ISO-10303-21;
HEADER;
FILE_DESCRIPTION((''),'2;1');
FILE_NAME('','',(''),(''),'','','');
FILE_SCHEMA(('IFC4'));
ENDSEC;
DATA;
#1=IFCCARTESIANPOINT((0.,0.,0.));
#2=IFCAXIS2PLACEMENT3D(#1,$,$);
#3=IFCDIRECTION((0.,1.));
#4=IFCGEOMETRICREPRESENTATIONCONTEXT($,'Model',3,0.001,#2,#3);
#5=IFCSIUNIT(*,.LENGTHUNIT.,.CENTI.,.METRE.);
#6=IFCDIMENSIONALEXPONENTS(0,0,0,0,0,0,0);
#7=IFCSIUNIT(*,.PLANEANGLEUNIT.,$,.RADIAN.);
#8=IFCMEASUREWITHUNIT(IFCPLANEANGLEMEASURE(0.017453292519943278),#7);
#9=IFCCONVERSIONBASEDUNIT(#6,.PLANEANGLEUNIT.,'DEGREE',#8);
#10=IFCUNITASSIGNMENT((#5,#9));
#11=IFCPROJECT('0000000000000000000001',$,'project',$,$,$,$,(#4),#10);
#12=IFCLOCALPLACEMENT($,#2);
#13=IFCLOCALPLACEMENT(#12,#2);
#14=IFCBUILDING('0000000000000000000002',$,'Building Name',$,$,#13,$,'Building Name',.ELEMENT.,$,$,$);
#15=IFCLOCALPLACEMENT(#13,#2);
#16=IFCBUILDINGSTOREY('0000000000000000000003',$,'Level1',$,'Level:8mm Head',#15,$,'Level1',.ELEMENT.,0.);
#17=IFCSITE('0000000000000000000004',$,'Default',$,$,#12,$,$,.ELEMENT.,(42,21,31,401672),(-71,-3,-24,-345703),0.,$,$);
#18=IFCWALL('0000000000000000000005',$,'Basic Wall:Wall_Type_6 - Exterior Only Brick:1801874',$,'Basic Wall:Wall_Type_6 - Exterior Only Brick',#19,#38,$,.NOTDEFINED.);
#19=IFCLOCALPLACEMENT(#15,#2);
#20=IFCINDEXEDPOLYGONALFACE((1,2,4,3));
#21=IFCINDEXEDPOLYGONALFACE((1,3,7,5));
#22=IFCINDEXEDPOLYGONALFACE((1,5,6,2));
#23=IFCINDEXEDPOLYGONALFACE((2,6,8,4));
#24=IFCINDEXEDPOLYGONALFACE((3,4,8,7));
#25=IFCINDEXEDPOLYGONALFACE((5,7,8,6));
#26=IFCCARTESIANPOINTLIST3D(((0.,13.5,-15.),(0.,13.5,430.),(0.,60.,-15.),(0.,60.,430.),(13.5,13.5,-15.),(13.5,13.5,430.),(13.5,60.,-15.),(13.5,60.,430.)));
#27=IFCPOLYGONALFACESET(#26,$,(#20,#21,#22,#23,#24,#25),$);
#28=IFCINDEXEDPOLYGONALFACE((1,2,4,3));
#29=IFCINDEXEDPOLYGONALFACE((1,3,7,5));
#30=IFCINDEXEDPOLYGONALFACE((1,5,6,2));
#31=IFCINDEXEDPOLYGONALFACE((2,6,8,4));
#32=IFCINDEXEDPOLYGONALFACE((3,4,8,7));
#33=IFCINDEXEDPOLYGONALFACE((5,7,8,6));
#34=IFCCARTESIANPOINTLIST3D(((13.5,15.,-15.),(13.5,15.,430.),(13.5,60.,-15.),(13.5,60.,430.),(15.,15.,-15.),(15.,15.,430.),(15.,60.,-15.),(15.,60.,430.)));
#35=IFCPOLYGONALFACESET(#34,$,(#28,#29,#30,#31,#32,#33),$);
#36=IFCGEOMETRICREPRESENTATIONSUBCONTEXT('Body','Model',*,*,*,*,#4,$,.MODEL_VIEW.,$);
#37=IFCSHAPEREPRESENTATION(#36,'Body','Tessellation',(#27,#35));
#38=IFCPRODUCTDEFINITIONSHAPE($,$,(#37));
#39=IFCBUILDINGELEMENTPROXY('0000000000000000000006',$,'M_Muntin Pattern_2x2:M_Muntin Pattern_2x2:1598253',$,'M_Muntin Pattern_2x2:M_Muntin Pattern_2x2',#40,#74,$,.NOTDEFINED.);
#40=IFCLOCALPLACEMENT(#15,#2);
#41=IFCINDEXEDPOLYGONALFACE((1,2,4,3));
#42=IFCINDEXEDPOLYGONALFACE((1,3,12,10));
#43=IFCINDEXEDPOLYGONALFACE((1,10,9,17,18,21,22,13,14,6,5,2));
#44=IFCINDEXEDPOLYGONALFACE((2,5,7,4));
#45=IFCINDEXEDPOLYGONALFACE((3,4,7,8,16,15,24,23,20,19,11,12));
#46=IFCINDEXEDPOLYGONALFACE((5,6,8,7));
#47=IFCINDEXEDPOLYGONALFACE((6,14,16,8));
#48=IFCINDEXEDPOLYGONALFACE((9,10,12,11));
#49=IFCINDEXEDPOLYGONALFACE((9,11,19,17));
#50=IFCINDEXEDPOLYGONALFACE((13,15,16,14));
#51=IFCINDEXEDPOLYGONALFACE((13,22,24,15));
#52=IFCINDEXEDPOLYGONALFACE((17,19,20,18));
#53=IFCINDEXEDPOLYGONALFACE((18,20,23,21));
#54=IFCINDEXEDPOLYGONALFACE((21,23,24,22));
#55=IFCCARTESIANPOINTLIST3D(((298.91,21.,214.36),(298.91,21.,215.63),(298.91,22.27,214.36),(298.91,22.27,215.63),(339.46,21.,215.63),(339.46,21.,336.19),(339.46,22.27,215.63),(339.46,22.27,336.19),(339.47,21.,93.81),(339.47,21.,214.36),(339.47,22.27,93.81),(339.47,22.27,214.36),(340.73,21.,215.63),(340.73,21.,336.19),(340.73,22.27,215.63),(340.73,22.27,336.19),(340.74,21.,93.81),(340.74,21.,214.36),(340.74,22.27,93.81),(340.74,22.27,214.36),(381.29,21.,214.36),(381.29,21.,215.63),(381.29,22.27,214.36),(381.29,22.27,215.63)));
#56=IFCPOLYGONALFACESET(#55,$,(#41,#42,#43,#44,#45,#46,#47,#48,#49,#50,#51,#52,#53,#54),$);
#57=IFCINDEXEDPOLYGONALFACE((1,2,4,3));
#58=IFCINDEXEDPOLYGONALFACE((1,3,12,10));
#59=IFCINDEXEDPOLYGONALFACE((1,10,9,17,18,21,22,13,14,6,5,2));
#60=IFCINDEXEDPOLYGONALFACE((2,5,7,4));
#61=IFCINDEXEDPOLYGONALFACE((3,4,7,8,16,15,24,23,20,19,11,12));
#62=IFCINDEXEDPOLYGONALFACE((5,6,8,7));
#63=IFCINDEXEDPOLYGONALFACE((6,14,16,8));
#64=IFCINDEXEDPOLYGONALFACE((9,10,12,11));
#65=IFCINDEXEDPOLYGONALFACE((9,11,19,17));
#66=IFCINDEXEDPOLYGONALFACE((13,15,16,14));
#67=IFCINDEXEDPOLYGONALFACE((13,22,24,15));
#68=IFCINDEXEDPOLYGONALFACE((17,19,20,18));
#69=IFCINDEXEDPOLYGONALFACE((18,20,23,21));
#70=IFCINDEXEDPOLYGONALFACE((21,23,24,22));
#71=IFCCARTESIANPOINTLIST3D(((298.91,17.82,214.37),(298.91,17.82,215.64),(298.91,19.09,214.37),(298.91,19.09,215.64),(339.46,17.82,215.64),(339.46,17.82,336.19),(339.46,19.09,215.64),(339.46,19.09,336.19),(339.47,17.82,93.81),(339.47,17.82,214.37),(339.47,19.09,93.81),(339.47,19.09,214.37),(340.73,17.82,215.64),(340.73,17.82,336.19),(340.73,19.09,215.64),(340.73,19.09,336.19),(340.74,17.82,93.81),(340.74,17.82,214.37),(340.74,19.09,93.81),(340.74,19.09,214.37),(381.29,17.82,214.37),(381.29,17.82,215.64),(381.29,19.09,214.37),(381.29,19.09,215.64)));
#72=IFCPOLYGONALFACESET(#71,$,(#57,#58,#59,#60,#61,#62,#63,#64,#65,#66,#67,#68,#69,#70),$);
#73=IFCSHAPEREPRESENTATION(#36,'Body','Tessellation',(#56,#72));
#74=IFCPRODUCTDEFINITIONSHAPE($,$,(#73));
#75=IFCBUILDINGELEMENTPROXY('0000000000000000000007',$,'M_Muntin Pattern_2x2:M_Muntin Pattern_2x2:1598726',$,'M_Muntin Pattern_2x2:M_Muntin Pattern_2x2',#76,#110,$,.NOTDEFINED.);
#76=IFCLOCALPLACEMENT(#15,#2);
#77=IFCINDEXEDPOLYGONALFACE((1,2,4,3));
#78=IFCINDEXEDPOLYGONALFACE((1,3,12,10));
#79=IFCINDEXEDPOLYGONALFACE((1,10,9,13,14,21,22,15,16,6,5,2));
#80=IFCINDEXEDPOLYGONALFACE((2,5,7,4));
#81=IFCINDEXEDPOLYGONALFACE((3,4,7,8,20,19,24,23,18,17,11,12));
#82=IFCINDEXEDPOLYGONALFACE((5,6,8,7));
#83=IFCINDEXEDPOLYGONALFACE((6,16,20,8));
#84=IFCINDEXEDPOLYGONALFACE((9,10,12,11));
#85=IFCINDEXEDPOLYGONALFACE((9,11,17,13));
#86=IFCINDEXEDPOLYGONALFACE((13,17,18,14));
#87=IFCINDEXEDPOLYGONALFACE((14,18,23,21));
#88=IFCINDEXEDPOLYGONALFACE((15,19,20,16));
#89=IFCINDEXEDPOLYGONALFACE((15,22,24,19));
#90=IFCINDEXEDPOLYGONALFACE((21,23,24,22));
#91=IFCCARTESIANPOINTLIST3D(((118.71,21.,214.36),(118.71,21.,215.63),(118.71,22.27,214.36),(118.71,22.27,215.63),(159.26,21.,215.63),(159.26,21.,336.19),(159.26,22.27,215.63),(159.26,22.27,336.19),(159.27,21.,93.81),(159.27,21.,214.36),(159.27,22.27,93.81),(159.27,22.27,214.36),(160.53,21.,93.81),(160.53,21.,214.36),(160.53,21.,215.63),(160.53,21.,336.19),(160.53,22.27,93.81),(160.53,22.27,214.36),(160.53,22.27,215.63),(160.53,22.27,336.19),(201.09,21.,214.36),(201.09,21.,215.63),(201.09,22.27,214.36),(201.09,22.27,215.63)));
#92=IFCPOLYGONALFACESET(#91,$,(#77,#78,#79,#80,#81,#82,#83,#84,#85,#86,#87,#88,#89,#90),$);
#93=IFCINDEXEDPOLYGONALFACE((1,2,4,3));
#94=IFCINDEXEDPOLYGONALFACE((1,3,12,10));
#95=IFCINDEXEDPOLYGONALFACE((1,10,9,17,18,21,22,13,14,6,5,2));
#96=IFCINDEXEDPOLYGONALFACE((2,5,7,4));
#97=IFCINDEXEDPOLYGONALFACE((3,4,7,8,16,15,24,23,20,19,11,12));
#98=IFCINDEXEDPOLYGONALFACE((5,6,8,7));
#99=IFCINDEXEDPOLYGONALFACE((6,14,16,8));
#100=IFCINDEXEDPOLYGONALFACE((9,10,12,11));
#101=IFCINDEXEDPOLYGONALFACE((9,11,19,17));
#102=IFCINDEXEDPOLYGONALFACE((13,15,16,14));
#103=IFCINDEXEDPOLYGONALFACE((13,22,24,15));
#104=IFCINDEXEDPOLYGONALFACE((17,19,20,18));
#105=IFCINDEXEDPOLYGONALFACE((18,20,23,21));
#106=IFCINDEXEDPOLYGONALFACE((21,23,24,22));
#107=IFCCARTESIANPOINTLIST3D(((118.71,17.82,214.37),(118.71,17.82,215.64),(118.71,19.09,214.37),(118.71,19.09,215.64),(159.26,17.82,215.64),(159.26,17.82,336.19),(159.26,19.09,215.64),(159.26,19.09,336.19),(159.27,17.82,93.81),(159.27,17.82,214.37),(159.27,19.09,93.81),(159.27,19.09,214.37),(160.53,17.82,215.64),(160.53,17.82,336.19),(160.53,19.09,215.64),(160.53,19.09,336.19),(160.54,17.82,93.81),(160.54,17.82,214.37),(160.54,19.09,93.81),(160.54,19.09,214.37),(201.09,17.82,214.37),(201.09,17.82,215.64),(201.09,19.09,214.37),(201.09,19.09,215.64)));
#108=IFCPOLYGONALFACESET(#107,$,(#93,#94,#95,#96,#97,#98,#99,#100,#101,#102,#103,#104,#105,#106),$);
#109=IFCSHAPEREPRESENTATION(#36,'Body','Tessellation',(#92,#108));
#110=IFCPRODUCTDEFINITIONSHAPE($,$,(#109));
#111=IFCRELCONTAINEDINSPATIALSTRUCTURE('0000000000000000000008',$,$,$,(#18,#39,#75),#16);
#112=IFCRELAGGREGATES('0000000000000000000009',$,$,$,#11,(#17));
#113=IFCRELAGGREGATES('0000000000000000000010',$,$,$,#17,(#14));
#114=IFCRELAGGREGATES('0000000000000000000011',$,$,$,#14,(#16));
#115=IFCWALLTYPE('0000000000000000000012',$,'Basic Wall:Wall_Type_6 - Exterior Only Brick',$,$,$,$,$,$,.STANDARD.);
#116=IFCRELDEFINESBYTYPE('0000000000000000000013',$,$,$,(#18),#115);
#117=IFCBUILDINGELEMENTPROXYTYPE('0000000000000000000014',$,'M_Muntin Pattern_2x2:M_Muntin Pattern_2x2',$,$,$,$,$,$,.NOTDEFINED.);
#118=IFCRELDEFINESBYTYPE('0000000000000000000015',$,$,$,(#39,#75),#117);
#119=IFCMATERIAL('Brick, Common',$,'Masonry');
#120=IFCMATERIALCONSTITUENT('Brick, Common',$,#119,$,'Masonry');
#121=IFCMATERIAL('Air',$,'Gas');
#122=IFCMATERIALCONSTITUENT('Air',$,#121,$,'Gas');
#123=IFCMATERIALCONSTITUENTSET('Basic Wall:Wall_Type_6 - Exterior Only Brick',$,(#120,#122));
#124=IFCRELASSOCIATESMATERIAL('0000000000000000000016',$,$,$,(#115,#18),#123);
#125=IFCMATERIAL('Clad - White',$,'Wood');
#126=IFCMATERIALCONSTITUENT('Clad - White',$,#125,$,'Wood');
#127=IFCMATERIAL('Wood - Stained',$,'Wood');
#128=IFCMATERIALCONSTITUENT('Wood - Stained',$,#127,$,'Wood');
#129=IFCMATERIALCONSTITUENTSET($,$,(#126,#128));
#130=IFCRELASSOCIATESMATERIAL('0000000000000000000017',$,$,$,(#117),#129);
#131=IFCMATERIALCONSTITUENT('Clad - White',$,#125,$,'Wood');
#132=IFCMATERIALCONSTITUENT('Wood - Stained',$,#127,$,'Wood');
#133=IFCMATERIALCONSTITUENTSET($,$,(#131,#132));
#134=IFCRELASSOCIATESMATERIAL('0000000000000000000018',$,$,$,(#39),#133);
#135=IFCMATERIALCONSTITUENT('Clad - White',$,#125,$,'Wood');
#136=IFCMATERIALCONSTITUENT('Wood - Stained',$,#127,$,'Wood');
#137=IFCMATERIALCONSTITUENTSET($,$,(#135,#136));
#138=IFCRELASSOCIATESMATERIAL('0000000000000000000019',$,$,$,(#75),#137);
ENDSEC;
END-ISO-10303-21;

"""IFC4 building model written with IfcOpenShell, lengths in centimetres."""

from ifc_helpers import new_model, entity, si_unit, converted_unit, direction, frame, origin, place, context, subcontext, project, spatial, indexed_curve, outline, extrude, source, transform, mapped, material, constituent, constituent_set, type_object, type_shapes, element, save


model = new_model("IFC4")

# Units and contexts
model_context = context("Model", 3, precision=0.001, world=origin(), true_north=direction((0.0, 1.0)))
body_context = subcontext(model_context, "Body", "Model", "MODEL_VIEW")
ifc_project = project(units=[si_unit("LENGTHUNIT", "METRE", prefix="CENTI"), converted_unit("PLANEANGLEUNIT", "DEGREE", entity("IfcPlaneAngleMeasure", 0.017453292519943278), si_unit("PLANEANGLEUNIT", "RADIAN"), dimensions=[0, 0, 0, 0, 0, 0, 0])], contexts=[model_context])

# Site, building, storey
site_placement = place(None, origin())
site = spatial("IfcSite", under=ifc_project, at=site_placement, Name="Default", CompositionType="ELEMENT", RefLatitude=(42, 21, 31, 401672), RefLongitude=(-71, -3, -24, -345703), RefElevation=0.0)
building_placement = place(site_placement, origin())
building = spatial("IfcBuilding", under=site, at=building_placement, Name="Building Name", LongName="Building Name", CompositionType="ELEMENT")
storey_placement = place(building_placement, origin())
storey = spatial("IfcBuildingStorey", under=building, at=storey_placement, Name="Level1", ObjectType="Level:8mm Head", LongName="Level1", CompositionType="ELEMENT", Elevation=0.0)

# Shared definitions
ifc_material_1 = material(Name="Brick, Common", Category="Masonry")
ifc_material_2 = material(Name="Air", Category="Gas")

# Wall
ifc_constituent_1 = constituent(ifc_material_1, Name="Brick, Common", Category="Masonry")
ifc_constituent_2 = constituent(ifc_material_2, Name="Air", Category="Gas")
ifc_constituent_set_1 = constituent_set(constituents=[ifc_constituent_1, ifc_constituent_2], Name="Basic Wall:Wall_Type_6 - Exterior Only Brick")
wall_type_1 = type_object("IfcWallType", Name="Basic Wall:Wall_Type_6 - Exterior Only Brick", PredefinedType="STANDARD", material=ifc_constituent_set_1)
wall_1_placement = place(storey_placement, frame((7.5, 15.0, -15.0), z_axis=(0.0, 0.0, 1.0), x_axis=(0.0, 1.0, 0.0)))
element("IfcWall", 1, at=wall_1_placement, inside=storey, type_object=wall_type_1, material=ifc_constituent_set_1, Name="Basic Wall:Wall_Type_6 - Exterior Only Brick:1801874", ObjectType="Basic Wall:Wall_Type_6 - Exterior Only Brick", PredefinedType="NOTDEFINED", context=body_context, shape_type="SweptSolid", body=[
    extrude(outline(indexed_curve([(-6.75, -23.25), (6.75, -23.25), (6.75, 23.25), (-6.75, 23.25), (-6.75, -23.25)], self_intersect=False)), frame((21.75, 0.75, 0.0), z_axis=(0.0, 0.0, 1.0), x_axis=(0.0, -1.0, 0.0)), (0.0, 0.0, 1.0), 445.0),
    extrude(outline(indexed_curve([(-0.75, -22.5), (0.75, -22.5), (0.75, 22.5), (-0.75, 22.5), (-0.75, -22.5)], self_intersect=False)), frame((22.5, -6.75, 0.0), z_axis=(0.0, 0.0, 1.0), x_axis=(0.0, 1.0, 0.0)), (0.0, 0.0, 1.0), 445.0),
])

# Building element proxies
ifc_material_3 = material(Name="Clad - White", Category="Wood")
ifc_constituent_3 = constituent(ifc_material_3, Name="Clad - White", Category="Wood")
ifc_material_4 = material(Name="Wood - Stained", Category="Wood")
ifc_constituent_4 = constituent(ifc_material_4, Name="Wood - Stained", Category="Wood")
ifc_constituent_set_2 = constituent_set(constituents=[ifc_constituent_3, ifc_constituent_4])
ifc_constituent_5 = constituent(ifc_material_3, Name="Clad - White", Category="Wood")
ifc_constituent_6 = constituent(ifc_material_4, Name="Wood - Stained", Category="Wood")
ifc_constituent_set_3 = constituent_set(constituents=[ifc_constituent_5, ifc_constituent_6])
building_element_proxy_type = type_object("IfcBuildingElementProxyType", Name="M_Muntin Pattern_2x2:M_Muntin Pattern_2x2", PredefinedType="NOTDEFINED", material=ifc_constituent_set_3)
shared_shape_1 = source(origin(), body_context, "Body", "SweptSolid", [
    extrude(outline(indexed_curve([(0.64, -0.64), (121.19, -0.64), (121.19, 0.63), (0.64, 0.63), (0.64, 41.19), (-0.63, 41.19), (-0.63, 0.63), (-121.19, 0.63), (-121.19, -0.64), (-0.63, -0.64), (-0.63, -41.19), (0.64, -41.19), (0.64, -0.64)], self_intersect=False)), frame((0.0, 0.95, 121.19), z_axis=(0.0, 1.0, 0.0), x_axis=(0.0, 0.0, 1.0)), (0.0, 0.0, 1.0), 1.27),
    extrude(outline(indexed_curve([(0.64, -0.64), (121.19, -0.64), (121.19, 0.63), (0.64, 0.63), (0.64, 41.19), (-0.63, 41.19), (-0.63, 0.63), (-121.19, 0.63), (-121.19, -0.64), (-0.63, -0.64), (-0.63, -41.19), (0.64, -41.19), (0.64, -0.64)], self_intersect=False)), frame((0.0, -2.22, 121.19), z_axis=(0.0, 1.0, 0.0), x_axis=(0.0, 0.0, 1.0)), (0.0, 0.0, 1.0), 1.27),
])
type_shapes(building_element_proxy_type, [shared_shape_1])
proxy_1_placement = place(storey_placement, frame((340.1, 20.05, 93.81)))
element("IfcBuildingElementProxy", 2, at=proxy_1_placement, inside=storey, type_object=building_element_proxy_type, material=ifc_constituent_set_2, Name="M_Muntin Pattern_2x2:M_Muntin Pattern_2x2:1598253", ObjectType="M_Muntin Pattern_2x2:M_Muntin Pattern_2x2", PredefinedType="NOTDEFINED", context=body_context, shape_type="MappedRepresentation", body=[
    mapped(shared_shape_1, transform((0.0, 0.0, 0.0), scale=1.0)),
])
ifc_constituent_7 = constituent(ifc_material_3, Name="Clad - White", Category="Wood")
ifc_constituent_8 = constituent(ifc_material_4, Name="Wood - Stained", Category="Wood")
ifc_constituent_set_4 = constituent_set(constituents=[ifc_constituent_7, ifc_constituent_8])
proxy_2_placement = place(storey_placement, frame((159.9, 20.05, 93.81)))
element("IfcBuildingElementProxy", 3, at=proxy_2_placement, inside=storey, type_object=building_element_proxy_type, material=ifc_constituent_set_4, Name="M_Muntin Pattern_2x2:M_Muntin Pattern_2x2:1598726", ObjectType="M_Muntin Pattern_2x2:M_Muntin Pattern_2x2", PredefinedType="NOTDEFINED", context=body_context, shape_type="MappedRepresentation", body=[
    mapped(shared_shape_1, transform((0.0, 0.0, 0.0), scale=1.0)),
])

save(model, "model.ifc")
